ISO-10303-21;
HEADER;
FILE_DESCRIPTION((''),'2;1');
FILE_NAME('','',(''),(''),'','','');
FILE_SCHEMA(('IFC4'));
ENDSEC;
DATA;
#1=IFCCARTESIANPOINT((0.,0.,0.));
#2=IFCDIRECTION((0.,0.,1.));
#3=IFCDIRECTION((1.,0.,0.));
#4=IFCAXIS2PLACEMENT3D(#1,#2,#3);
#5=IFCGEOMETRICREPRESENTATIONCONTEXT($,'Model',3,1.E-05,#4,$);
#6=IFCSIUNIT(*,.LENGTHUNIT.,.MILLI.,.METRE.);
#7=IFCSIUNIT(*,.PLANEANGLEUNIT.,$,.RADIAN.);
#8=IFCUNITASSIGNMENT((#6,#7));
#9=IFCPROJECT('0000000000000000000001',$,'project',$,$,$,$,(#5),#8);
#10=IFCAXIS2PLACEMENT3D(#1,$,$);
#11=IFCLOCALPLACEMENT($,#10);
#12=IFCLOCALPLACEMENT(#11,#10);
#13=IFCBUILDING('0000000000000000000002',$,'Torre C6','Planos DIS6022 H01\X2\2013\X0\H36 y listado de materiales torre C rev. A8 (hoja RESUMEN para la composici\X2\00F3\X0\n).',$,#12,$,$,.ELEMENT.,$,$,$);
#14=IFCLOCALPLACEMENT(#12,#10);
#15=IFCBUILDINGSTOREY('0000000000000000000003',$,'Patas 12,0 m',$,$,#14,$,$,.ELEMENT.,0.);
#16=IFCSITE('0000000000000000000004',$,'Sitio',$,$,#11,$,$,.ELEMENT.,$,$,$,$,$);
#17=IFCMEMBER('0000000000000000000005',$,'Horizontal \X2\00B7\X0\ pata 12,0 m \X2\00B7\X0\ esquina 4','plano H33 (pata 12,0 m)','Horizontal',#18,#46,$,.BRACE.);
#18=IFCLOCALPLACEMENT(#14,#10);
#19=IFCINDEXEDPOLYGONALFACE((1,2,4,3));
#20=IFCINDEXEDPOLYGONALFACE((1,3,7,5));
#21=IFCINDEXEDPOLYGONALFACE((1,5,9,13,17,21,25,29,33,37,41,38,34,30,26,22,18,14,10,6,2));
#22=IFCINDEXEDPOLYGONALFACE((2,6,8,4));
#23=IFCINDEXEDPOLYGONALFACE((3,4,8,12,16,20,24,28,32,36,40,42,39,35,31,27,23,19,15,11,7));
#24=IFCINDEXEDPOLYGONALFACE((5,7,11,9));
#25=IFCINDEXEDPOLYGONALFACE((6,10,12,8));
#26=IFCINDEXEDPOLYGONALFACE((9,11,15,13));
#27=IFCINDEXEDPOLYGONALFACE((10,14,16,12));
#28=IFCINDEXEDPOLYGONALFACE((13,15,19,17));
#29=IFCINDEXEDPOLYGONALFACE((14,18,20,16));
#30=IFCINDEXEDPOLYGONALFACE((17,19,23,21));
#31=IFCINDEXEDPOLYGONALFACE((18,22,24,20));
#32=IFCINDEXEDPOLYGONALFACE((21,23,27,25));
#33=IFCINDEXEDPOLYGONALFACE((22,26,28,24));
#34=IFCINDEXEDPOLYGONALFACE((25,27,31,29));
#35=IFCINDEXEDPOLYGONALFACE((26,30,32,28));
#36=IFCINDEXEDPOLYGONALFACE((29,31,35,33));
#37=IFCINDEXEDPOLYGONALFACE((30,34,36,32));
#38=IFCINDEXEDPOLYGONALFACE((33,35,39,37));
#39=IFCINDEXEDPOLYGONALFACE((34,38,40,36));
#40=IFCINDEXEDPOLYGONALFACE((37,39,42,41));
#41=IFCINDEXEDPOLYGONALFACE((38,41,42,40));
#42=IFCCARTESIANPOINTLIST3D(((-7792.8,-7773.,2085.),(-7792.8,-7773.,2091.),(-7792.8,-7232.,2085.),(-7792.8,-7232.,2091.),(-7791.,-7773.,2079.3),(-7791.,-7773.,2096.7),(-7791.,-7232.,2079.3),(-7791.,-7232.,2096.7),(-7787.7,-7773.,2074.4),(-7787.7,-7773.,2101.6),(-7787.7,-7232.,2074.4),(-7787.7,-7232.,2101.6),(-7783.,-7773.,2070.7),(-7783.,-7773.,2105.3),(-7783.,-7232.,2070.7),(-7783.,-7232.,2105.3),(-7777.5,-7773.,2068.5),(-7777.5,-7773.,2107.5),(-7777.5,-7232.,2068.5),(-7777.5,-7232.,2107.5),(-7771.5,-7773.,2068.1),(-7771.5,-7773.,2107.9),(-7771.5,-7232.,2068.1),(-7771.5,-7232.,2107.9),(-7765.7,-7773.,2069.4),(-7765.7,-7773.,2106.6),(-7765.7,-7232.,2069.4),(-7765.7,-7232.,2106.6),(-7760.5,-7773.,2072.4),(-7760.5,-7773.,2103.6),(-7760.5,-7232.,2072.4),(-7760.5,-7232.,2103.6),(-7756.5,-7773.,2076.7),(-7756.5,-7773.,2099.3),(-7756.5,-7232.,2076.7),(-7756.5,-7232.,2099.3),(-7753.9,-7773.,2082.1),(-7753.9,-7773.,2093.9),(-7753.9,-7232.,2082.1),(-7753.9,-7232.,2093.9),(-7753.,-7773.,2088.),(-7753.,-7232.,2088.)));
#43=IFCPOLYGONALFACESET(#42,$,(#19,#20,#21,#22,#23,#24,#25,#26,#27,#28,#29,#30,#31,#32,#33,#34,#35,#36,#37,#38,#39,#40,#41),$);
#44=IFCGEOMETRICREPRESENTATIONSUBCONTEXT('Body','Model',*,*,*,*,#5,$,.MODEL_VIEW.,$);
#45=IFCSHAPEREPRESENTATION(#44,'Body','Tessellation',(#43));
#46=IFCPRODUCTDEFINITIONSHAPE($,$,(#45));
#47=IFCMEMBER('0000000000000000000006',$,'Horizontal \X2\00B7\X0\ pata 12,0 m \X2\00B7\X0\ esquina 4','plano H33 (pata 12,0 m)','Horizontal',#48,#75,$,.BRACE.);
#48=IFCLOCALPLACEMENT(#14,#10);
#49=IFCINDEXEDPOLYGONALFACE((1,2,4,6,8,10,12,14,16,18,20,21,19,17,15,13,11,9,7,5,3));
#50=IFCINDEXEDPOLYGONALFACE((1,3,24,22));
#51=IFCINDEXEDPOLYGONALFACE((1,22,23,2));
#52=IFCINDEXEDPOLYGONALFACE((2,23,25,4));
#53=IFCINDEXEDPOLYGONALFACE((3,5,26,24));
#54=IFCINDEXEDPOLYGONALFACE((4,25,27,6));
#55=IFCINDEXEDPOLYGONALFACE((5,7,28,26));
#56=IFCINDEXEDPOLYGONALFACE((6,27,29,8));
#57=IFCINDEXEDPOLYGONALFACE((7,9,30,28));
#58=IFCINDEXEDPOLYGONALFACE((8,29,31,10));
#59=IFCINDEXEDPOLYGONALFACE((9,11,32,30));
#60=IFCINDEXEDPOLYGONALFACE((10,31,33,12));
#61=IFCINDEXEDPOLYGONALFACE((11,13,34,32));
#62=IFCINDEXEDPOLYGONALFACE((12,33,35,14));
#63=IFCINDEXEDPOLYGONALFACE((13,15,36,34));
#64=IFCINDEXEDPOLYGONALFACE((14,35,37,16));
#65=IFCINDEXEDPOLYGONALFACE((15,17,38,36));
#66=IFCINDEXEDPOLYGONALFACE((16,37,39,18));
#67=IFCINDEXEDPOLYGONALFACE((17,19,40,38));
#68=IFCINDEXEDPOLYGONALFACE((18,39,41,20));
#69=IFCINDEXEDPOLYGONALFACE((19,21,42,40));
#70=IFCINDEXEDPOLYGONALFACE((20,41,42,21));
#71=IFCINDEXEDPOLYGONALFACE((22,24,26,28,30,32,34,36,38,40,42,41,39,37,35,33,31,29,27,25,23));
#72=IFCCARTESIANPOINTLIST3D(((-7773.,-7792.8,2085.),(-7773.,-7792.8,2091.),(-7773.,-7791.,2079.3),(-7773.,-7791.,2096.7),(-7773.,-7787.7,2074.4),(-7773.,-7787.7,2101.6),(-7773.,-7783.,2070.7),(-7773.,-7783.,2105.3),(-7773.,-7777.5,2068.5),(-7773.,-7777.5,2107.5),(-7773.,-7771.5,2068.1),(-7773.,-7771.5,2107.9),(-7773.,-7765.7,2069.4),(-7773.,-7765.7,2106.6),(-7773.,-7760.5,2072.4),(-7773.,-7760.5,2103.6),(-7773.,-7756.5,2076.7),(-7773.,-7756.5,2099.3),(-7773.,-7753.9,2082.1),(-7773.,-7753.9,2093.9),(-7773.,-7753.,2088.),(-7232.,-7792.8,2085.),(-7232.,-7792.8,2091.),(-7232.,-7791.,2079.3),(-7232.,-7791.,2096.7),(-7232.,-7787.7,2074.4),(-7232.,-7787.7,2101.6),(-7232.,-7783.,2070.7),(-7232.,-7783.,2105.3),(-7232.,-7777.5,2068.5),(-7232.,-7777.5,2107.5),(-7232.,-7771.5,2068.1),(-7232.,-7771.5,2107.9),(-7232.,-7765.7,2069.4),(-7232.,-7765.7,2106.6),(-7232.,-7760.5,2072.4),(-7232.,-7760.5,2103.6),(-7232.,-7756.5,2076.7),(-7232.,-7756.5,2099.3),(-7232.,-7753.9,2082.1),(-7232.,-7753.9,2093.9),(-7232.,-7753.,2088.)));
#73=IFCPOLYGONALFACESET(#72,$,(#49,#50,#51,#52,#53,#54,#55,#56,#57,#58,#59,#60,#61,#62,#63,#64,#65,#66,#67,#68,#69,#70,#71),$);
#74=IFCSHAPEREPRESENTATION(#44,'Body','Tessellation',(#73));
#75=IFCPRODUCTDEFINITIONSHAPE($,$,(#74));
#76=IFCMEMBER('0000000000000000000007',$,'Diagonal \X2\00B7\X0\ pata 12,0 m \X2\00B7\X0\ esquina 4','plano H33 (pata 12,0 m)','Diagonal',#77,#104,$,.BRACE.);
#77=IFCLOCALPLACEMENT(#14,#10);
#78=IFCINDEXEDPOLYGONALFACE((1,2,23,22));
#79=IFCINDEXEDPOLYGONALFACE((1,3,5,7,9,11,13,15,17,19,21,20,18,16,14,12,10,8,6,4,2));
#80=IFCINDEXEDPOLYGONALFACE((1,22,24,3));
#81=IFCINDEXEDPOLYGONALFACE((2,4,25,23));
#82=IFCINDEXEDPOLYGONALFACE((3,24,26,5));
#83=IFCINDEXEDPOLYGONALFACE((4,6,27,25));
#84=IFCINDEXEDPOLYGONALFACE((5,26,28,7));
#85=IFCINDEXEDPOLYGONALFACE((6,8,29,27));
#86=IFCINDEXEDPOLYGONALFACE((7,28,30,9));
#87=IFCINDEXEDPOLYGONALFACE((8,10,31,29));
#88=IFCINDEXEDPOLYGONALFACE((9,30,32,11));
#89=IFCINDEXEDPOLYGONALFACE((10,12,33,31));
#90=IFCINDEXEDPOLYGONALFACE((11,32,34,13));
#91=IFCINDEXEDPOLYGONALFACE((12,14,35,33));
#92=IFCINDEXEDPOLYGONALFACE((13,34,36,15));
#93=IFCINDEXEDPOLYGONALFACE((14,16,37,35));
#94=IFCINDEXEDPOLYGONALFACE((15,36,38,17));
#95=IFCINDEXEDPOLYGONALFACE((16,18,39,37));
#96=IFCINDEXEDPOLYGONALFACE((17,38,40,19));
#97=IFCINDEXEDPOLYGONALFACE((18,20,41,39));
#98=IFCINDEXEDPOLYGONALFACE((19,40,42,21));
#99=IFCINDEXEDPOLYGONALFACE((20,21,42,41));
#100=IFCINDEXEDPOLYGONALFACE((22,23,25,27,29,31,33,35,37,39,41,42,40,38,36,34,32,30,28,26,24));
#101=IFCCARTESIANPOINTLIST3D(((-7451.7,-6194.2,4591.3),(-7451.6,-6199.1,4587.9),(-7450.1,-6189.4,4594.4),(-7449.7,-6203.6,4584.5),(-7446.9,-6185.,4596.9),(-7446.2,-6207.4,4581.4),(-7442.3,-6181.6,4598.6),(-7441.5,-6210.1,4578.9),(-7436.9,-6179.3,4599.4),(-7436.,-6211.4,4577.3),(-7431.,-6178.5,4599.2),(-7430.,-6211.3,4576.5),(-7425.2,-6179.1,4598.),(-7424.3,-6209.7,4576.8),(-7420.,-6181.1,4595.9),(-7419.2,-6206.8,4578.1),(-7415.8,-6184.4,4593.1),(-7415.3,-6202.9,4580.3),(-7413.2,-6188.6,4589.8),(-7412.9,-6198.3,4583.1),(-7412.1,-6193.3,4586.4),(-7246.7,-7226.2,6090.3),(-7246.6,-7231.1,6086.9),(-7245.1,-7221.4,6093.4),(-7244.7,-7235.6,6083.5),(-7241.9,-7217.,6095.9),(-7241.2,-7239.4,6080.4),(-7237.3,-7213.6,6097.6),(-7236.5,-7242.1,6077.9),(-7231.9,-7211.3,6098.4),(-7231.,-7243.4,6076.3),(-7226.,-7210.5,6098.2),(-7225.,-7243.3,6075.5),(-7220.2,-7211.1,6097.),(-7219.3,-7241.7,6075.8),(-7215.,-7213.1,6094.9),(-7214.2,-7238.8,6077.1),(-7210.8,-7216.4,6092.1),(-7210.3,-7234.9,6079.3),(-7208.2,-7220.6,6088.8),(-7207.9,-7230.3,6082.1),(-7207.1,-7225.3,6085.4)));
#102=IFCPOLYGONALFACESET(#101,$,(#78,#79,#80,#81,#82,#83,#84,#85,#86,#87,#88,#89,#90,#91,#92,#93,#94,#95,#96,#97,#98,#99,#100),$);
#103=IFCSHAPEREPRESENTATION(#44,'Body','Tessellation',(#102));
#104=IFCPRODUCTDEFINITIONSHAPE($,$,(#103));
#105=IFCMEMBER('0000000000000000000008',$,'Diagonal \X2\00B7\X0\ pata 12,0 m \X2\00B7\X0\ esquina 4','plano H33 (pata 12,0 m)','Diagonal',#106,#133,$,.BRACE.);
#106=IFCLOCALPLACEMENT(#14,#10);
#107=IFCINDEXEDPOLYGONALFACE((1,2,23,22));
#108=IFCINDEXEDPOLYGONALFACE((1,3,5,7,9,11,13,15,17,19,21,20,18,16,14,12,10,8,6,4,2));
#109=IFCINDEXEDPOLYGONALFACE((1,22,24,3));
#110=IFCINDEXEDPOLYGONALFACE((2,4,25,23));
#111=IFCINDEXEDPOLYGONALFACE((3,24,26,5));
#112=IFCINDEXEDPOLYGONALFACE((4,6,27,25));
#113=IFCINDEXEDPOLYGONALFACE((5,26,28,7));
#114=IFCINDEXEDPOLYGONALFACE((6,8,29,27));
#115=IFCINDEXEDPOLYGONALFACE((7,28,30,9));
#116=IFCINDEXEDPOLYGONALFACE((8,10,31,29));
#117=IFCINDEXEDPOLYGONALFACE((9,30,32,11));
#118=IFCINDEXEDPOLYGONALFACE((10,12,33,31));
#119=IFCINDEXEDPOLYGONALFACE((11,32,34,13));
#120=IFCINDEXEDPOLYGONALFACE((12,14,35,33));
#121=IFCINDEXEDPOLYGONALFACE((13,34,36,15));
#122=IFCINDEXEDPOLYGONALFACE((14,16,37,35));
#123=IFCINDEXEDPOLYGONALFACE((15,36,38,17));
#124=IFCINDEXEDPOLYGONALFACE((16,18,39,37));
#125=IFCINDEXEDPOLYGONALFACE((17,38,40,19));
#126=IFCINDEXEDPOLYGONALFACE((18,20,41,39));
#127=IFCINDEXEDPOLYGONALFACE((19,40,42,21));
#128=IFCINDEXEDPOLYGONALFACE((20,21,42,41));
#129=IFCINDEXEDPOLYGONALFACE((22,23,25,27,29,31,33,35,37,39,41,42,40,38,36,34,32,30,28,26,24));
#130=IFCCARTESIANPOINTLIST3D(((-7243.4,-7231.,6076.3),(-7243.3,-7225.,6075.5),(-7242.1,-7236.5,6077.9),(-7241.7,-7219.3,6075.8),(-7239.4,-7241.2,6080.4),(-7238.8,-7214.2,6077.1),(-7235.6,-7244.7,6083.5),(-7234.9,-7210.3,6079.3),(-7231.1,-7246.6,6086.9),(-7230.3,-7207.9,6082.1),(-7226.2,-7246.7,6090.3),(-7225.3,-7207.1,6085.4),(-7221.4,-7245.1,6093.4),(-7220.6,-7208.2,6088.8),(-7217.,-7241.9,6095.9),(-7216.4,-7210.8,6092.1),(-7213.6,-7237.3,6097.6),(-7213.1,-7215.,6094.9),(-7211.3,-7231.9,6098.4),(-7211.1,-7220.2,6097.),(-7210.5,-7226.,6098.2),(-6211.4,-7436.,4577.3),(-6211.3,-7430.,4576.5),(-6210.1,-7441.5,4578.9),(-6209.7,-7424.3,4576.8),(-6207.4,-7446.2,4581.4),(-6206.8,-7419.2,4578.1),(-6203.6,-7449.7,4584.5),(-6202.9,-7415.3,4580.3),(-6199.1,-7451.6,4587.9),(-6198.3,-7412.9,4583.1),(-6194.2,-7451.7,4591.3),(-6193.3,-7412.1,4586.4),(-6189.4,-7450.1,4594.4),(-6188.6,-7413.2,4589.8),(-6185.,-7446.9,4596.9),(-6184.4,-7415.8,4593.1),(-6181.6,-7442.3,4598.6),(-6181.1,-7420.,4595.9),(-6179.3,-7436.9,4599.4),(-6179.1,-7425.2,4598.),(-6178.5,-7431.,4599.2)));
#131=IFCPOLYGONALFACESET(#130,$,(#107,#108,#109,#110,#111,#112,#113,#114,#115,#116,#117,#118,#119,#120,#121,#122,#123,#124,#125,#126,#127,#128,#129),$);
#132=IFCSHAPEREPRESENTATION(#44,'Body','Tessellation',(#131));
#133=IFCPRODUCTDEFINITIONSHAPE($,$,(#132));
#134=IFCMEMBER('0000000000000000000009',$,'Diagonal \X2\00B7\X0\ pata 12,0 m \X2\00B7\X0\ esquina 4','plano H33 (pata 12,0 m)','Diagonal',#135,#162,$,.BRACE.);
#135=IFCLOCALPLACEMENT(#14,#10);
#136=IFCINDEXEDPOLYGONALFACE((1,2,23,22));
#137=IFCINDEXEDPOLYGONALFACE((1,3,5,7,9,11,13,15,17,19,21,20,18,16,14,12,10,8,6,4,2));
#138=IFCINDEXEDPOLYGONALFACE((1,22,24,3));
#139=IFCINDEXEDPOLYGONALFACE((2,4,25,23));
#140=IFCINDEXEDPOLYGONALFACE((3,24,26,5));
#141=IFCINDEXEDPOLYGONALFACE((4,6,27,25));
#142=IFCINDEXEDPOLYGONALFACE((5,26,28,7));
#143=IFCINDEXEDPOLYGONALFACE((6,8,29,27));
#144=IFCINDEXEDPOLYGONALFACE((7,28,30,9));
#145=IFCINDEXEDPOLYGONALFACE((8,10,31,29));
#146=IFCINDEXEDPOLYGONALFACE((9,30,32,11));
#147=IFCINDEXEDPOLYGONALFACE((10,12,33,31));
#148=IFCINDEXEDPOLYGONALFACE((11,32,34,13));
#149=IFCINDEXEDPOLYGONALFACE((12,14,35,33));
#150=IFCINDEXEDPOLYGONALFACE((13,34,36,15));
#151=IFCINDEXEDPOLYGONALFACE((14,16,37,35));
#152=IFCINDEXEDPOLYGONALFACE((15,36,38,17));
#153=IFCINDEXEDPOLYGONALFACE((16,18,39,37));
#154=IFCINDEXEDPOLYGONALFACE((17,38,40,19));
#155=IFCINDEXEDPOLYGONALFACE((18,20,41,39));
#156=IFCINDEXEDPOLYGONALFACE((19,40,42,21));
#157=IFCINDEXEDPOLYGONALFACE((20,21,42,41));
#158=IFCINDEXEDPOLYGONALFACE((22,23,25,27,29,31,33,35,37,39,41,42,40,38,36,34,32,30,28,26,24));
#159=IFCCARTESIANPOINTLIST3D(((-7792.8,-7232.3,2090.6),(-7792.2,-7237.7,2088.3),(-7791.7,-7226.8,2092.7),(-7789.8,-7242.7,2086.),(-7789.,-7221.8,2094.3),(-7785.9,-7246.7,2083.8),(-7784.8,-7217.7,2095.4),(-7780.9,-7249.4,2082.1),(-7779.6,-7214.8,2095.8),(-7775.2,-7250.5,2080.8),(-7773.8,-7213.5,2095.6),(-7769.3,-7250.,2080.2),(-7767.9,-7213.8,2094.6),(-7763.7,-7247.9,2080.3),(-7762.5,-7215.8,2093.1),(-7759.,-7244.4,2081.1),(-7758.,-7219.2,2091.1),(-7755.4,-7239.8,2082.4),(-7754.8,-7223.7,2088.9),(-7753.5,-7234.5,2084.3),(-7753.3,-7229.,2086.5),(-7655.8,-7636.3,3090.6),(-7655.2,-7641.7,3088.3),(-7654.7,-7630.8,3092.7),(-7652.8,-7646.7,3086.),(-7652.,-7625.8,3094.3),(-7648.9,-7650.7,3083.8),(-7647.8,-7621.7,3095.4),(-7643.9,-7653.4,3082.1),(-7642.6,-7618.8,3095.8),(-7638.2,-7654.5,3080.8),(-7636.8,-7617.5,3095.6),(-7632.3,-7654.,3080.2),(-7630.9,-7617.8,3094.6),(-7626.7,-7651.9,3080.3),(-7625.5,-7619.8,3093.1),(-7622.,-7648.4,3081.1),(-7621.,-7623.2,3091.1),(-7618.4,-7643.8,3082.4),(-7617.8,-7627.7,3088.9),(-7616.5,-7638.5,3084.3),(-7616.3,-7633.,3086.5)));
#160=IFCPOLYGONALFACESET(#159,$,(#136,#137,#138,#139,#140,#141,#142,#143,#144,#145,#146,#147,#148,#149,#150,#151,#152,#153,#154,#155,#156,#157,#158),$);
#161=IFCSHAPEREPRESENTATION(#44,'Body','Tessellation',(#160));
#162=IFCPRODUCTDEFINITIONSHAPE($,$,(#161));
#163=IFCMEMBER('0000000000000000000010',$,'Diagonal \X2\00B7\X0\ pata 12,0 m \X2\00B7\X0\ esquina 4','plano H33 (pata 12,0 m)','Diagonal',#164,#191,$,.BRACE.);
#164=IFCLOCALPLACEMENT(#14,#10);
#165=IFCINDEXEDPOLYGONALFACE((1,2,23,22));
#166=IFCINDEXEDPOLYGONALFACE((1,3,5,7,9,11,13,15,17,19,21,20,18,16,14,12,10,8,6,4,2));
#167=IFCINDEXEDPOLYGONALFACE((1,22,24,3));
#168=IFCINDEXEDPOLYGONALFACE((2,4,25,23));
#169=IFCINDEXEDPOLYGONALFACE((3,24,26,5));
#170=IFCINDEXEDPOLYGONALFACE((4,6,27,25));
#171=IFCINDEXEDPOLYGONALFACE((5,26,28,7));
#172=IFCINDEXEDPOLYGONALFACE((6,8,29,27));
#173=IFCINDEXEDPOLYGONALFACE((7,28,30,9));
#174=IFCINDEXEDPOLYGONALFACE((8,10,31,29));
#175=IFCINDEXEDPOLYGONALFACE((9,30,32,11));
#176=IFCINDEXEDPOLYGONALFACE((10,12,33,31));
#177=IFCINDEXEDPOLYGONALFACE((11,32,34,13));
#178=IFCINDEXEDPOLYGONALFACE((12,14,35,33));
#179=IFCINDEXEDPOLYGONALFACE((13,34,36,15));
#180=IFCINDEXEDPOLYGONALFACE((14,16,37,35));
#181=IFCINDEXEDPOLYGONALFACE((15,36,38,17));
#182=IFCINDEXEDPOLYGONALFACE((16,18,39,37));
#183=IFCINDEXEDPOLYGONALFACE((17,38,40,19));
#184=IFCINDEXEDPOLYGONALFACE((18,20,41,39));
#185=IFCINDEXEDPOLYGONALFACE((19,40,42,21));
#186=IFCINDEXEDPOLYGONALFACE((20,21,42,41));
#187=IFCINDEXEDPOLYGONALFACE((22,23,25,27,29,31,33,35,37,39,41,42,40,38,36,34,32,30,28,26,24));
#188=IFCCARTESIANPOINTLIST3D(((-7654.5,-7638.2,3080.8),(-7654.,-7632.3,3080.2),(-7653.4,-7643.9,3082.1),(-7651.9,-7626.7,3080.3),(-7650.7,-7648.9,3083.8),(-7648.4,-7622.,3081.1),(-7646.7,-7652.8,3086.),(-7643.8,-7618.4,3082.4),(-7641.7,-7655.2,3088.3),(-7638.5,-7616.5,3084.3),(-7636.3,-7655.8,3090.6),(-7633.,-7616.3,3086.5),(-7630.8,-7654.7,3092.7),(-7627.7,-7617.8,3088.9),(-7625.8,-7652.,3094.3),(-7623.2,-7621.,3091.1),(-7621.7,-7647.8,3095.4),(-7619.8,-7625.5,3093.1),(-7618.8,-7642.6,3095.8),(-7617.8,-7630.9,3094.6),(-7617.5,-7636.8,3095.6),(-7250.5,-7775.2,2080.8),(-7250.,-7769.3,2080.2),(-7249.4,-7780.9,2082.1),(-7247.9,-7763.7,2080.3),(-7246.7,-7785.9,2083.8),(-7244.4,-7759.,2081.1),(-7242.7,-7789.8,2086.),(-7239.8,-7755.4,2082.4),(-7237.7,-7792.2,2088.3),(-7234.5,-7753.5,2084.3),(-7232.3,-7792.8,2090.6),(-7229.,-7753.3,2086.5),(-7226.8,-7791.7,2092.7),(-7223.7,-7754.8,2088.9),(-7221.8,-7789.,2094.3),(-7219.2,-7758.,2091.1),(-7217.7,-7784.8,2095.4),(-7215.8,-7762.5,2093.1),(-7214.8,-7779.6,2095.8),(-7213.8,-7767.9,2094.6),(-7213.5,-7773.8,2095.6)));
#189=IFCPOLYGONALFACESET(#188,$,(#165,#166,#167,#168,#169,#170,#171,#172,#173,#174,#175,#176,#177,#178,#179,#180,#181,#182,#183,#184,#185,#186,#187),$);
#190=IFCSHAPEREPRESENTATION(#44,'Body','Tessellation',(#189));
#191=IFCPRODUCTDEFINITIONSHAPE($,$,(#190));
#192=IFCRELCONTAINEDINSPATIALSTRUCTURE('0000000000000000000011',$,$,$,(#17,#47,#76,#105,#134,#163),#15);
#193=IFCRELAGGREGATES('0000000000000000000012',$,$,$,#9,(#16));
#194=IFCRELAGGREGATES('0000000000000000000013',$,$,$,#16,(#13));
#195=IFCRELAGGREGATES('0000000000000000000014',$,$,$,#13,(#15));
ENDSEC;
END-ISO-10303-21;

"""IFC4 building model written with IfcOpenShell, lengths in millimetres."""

from ifc_helpers import new_model, si_unit, frame, origin, origin_with_axes, place, context, subcontext, project, spatial, circle, extrude, element, save


model = new_model("IFC4")

# Units and contexts
model_context = context("Model", 3, precision=1e-05, world=origin_with_axes())
body_context = subcontext(model_context, "Body", "Model", "MODEL_VIEW")
ifc_project = project(units=[si_unit("LENGTHUNIT", "METRE", prefix="MILLI"), si_unit("PLANEANGLEUNIT", "RADIAN")], contexts=[model_context])

# Site, building, storey
site_placement = place(None, origin())
site = spatial("IfcSite", under=ifc_project, at=site_placement, Name="Sitio", CompositionType="ELEMENT")
building_placement = place(site_placement, origin())
building = spatial("IfcBuilding", under=site, at=building_placement, Name="Torre C6", Description="Planos DIS6022 H01–H36 y listado de materiales torre C rev. A8 (hoja RESUMEN para la composición).", CompositionType="ELEMENT")
storey_placement = place(building_placement, origin())
storey = spatial("IfcBuildingStorey", under=building, at=storey_placement, Name="Patas 12,0 m", CompositionType="ELEMENT", Elevation=0.0)

# Members
for number, where, z_axis, x_axis, name in (
    (1, (-7773.0, -7232.0, 2088.0), (0.0, -1.0, 0.0), (1.0, 0.0, 0.0), "Horizontal · pata 12,0 m · esquina 4"),
    (2, (-7232.0, -7773.0, 2088.0), (-1.0, 0.0, 0.0), (0.0, 1.0, 0.0), "Horizontal · pata 12,0 m · esquina 4"),
):
    element("IfcMember", number, at=place(storey_placement, frame(where, z_axis=z_axis, x_axis=x_axis)), inside=storey, Name=name, Description="plano H33 (pata 12,0 m)", ObjectType="Horizontal", PredefinedType="BRACE", context=body_context, shape_type="SweptSolid", body=[
        extrude(circle(Radius=20.0), None, (0.0, 0.0, 1.0), 541.0),
    ])
for number, where, z_axis, x_axis, name in (
    (3, (-7227.0, -7227.0, 6087.0), (-0.111936, 0.563501, -0.818497), (0.807581, 0.531539, 0.2555), "Diagonal · pata 12,0 m · esquina 4"),
    (4, (-7227.0, -7227.0, 6087.0), (0.563501, -0.111936, -0.818497), (0.531539, 0.807581, 0.2555), "Diagonal · pata 12,0 m · esquina 4"),
):
    element("IfcMember", number, at=place(storey_placement, frame(where, z_axis=z_axis, x_axis=x_axis)), inside=storey, Name=name, Description="plano H33 (pata 12,0 m)", ObjectType="Diagonal", PredefinedType="BRACE", context=body_context, shape_type="SweptSolid", body=[
        extrude(circle(Radius=20.0), None, (0.0, 0.0, 1.0), 1831.4),
    ])
for number, where, z_axis, x_axis, name in (
    (5, (-7636.0, -7636.0, 3088.0), (-0.126013, 0.3716, -0.919801), (0.751308, 0.641219, 0.156123), "Diagonal · pata 12,0 m · esquina 4"),
    (6, (-7636.0, -7636.0, 3088.0), (0.3716, -0.126013, -0.919801), (0.641219, 0.751308, 0.156123), "Diagonal · pata 12,0 m · esquina 4"),
):
    element("IfcMember", number, at=place(storey_placement, frame(where, z_axis=z_axis, x_axis=x_axis)), inside=storey, Name=name, Description="plano H33 (pata 12,0 m)", ObjectType="Diagonal", PredefinedType="BRACE", context=body_context, shape_type="SweptSolid", body=[
        extrude(circle(Radius=20.0), None, (0.0, 0.0, 1.0), 1087.2),
    ])

save(model, "model.ifc")
